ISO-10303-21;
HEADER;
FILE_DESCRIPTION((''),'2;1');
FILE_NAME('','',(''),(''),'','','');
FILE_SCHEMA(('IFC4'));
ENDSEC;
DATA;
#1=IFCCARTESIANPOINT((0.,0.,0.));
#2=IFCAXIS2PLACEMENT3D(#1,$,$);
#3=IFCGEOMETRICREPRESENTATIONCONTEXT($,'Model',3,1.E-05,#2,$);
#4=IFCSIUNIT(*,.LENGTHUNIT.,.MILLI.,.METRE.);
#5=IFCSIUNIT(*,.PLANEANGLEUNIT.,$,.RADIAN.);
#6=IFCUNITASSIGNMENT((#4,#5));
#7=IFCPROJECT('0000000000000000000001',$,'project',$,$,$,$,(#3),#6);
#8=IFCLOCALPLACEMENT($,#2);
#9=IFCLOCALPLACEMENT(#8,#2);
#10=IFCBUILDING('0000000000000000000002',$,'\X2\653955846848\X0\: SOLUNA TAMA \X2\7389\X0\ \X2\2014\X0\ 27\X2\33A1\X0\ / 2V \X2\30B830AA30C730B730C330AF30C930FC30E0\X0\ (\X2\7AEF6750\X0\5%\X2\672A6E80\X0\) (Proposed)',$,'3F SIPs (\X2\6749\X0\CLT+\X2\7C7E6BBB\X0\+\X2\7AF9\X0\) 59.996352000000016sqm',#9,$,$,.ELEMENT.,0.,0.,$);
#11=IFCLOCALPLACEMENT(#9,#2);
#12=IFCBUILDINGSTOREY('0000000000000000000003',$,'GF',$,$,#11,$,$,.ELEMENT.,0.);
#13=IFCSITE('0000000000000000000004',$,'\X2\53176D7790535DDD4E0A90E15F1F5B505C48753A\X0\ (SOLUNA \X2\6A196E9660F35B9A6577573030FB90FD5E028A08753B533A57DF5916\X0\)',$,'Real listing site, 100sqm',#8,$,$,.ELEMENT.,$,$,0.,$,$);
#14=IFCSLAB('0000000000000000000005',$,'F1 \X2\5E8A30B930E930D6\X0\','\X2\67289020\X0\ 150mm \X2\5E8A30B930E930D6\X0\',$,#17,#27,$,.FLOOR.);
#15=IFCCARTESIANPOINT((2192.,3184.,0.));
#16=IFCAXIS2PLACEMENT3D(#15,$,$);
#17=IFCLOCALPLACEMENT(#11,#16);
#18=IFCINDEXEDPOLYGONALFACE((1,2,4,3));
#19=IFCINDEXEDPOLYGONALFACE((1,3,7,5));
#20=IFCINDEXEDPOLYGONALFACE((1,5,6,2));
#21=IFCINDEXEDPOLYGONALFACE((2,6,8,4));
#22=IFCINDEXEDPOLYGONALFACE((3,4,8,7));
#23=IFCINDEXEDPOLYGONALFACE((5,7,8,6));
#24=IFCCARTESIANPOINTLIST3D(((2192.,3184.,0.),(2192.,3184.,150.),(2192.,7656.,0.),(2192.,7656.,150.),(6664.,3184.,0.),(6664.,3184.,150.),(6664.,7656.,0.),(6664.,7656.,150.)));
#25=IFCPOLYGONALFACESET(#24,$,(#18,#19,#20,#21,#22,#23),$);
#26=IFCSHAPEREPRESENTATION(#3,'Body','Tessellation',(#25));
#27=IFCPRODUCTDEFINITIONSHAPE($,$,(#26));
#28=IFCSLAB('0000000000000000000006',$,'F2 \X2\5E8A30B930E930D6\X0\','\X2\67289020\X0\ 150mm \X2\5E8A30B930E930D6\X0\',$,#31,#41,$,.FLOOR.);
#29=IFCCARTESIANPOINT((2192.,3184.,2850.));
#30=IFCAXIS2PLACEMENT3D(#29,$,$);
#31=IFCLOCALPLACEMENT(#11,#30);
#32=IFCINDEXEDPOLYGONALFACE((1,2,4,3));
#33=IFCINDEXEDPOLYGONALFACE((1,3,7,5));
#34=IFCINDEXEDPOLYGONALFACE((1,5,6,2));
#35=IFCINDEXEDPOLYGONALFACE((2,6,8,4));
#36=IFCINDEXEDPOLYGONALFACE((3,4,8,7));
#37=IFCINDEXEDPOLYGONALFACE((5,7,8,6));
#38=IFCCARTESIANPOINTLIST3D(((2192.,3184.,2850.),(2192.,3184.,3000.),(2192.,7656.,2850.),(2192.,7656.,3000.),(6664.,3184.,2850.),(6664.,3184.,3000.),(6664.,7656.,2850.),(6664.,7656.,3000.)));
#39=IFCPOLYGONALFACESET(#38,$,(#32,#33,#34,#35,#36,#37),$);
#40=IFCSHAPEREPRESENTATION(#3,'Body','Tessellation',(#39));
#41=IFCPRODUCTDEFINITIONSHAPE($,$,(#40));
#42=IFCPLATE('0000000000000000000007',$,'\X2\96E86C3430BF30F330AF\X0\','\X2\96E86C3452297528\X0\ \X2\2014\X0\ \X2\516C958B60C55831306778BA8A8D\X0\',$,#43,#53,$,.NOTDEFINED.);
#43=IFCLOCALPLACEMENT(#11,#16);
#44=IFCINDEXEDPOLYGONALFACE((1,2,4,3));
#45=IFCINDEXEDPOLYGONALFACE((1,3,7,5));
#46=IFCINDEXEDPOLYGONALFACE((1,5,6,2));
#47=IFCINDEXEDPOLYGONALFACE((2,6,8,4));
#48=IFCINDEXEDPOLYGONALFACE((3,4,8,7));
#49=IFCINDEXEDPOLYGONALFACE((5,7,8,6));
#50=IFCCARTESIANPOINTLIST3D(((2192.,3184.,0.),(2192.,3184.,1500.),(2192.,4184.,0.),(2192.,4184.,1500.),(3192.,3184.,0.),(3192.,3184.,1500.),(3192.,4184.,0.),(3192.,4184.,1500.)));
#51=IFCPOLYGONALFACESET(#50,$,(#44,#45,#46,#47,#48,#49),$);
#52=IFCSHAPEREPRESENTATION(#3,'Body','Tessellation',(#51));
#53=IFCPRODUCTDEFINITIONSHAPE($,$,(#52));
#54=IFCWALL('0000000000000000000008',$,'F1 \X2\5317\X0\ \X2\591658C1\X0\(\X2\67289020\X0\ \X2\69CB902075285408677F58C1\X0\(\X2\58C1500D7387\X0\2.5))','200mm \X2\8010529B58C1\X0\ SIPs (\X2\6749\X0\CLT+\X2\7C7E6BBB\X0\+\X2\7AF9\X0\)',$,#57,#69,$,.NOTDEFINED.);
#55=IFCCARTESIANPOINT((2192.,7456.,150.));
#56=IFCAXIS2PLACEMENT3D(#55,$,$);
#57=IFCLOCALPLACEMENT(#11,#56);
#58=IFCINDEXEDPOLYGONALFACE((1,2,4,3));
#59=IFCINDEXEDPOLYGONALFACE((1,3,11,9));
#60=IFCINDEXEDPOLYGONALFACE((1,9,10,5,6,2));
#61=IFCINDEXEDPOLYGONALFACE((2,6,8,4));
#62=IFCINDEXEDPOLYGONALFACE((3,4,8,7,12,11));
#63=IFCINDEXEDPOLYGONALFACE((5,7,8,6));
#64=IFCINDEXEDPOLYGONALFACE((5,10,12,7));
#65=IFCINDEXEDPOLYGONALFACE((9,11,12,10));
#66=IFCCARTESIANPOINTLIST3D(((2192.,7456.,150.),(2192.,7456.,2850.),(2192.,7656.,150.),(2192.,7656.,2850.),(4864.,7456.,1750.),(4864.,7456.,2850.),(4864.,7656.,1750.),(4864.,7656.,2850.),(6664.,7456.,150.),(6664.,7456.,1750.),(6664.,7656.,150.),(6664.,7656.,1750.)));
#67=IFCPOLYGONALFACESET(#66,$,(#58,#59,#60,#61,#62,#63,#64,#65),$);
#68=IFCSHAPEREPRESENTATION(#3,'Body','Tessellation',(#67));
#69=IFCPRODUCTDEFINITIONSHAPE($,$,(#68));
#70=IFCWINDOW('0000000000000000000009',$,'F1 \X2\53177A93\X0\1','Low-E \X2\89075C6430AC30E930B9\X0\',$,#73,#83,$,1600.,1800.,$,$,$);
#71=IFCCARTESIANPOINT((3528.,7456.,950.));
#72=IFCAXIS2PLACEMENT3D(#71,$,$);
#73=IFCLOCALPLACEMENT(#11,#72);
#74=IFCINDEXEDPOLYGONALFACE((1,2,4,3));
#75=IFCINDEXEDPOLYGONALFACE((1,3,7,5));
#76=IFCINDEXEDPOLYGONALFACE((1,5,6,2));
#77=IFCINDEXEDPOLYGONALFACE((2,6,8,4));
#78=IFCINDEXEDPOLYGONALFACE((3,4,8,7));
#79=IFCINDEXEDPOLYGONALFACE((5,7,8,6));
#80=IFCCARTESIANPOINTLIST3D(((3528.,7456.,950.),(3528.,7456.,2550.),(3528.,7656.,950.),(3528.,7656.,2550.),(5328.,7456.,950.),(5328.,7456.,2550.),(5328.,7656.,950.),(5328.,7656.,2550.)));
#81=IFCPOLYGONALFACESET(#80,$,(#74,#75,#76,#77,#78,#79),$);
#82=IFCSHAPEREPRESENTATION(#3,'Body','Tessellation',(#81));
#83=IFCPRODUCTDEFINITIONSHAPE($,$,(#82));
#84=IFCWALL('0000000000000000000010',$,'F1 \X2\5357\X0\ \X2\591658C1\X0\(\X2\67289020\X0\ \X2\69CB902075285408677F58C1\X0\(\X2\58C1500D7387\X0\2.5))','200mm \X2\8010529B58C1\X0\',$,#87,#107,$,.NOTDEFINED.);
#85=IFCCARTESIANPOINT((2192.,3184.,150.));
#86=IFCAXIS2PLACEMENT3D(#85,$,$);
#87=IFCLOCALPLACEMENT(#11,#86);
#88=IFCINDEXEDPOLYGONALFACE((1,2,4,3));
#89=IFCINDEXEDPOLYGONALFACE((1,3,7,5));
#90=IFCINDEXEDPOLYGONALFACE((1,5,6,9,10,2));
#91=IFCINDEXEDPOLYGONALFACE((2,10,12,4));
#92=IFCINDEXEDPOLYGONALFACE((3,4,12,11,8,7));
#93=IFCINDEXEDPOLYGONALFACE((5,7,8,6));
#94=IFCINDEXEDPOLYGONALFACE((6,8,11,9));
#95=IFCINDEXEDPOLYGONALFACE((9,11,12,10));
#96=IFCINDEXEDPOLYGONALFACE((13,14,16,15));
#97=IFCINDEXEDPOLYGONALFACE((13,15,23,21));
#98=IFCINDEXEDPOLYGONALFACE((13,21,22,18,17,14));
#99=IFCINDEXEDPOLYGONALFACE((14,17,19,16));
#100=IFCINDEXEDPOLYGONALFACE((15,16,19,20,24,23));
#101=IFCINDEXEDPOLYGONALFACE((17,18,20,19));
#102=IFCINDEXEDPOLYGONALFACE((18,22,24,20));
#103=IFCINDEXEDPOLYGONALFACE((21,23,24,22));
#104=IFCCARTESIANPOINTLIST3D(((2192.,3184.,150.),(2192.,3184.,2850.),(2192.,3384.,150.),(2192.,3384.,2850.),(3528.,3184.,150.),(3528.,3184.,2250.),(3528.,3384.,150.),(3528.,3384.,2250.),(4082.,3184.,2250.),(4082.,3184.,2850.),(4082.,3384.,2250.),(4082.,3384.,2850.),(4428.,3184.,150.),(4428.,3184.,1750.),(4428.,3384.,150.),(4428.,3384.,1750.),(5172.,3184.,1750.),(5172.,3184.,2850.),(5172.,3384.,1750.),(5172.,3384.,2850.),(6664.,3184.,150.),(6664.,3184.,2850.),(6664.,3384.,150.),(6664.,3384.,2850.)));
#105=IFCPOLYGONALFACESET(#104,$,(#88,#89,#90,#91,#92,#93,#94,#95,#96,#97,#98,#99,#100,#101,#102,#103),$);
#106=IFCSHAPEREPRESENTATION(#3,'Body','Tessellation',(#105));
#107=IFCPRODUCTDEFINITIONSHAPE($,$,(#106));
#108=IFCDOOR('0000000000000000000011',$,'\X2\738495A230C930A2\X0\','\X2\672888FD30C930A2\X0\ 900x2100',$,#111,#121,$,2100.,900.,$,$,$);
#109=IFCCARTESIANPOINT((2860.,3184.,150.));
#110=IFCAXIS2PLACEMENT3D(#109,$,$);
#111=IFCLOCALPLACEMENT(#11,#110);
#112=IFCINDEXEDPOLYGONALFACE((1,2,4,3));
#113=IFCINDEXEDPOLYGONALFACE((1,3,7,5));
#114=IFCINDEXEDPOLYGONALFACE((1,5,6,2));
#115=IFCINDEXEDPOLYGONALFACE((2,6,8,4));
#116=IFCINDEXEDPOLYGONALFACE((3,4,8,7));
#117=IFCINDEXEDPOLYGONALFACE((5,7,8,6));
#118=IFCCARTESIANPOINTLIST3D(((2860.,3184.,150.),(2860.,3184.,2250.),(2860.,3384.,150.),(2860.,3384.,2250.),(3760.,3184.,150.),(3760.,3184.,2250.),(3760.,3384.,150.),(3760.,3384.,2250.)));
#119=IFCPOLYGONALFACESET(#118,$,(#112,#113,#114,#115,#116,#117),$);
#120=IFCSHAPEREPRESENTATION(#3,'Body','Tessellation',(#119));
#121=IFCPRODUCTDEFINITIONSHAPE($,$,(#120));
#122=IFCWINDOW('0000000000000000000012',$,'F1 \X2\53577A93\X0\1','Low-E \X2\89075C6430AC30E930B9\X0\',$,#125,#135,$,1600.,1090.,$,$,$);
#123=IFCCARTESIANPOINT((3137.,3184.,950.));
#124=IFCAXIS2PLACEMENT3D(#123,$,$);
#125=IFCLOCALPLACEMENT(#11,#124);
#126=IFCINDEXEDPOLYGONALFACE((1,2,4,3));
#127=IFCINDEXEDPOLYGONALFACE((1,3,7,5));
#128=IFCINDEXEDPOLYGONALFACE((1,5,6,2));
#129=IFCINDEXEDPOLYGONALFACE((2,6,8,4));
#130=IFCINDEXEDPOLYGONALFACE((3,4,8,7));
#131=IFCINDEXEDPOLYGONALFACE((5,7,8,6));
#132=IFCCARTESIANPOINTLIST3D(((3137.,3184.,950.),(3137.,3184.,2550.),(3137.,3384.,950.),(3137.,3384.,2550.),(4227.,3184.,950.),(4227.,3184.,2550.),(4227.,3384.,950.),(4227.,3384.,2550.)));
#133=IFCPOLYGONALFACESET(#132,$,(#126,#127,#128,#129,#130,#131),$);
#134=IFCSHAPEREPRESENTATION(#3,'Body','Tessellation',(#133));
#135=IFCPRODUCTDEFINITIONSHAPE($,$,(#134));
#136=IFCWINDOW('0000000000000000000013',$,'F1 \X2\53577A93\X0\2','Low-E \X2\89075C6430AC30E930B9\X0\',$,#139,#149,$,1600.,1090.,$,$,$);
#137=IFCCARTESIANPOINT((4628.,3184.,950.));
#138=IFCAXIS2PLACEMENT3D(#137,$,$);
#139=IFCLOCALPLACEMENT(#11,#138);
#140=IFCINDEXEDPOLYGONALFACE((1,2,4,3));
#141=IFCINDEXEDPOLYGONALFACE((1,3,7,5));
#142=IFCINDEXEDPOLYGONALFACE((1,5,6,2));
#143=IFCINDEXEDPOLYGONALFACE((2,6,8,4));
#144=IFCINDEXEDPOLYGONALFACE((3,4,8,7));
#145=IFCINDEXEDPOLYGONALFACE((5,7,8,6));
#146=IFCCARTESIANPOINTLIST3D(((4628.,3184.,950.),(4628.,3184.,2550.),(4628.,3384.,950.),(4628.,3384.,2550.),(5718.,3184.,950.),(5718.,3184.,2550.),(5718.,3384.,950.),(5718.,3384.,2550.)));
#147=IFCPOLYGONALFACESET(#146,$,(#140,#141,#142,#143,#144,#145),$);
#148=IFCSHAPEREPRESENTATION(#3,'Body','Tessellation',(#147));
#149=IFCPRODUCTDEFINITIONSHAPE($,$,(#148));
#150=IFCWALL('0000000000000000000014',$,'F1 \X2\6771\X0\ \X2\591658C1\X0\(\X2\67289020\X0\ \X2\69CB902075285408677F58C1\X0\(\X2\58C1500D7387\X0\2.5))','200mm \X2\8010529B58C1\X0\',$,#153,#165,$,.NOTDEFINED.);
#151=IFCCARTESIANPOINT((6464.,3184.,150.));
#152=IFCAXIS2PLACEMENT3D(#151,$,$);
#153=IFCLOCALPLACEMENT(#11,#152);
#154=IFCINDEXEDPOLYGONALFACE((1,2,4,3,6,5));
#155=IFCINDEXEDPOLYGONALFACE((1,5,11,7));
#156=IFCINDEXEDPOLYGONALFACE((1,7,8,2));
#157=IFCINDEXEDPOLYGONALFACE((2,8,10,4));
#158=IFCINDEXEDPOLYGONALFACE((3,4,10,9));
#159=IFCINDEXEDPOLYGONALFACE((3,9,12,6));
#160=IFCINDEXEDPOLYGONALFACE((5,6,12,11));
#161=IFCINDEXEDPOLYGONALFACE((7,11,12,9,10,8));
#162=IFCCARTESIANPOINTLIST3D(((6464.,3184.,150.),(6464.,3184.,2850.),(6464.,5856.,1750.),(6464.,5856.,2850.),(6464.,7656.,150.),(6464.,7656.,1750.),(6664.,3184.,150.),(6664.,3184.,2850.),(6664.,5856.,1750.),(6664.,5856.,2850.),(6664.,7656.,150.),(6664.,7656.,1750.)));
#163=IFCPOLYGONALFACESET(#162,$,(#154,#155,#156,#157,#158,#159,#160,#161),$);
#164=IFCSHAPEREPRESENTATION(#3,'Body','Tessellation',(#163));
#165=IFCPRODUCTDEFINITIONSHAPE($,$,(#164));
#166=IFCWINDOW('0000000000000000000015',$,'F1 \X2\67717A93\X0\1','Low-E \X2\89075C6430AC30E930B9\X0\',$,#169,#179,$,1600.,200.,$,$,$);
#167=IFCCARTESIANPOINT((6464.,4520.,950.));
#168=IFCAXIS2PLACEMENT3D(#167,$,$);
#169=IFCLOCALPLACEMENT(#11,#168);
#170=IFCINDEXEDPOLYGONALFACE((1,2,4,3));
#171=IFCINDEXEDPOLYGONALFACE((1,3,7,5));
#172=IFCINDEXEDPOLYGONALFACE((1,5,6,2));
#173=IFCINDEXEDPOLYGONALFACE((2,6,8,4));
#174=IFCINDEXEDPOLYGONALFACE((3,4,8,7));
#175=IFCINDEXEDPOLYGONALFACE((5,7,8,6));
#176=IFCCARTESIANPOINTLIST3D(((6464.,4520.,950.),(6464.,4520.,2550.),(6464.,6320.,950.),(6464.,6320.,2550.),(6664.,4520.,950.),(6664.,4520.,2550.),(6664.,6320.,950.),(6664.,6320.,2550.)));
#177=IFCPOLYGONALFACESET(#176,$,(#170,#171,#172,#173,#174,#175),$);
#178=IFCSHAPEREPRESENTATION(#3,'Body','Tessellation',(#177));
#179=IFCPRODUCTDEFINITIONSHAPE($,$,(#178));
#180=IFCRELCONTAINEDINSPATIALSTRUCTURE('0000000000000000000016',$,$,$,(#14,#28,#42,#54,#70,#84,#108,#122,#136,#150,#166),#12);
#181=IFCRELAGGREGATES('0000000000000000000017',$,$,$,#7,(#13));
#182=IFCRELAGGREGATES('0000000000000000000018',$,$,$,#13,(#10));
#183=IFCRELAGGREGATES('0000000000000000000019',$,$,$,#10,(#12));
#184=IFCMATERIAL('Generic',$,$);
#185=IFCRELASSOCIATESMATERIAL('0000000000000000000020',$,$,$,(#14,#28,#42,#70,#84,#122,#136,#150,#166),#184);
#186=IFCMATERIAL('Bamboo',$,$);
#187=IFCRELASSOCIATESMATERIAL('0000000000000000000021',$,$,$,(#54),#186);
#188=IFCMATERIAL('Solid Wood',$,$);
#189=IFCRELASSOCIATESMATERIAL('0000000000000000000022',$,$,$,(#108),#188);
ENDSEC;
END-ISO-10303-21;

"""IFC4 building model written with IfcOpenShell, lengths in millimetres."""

from ifc_helpers import new_model, si_unit, frame, frame_2d, origin, place, context, project, spatial, rectangle, extrude, material, element, fill, save


model = new_model("IFC4")

# Units and contexts
model_context = context("Model", 3, precision=1e-05, world=origin())
ifc_project = project(units=[si_unit("LENGTHUNIT", "METRE", prefix="MILLI"), si_unit("PLANEANGLEUNIT", "RADIAN")], contexts=[model_context])

# Site, building, storey
site_placement = place(None, origin())
site = spatial("IfcSite", under=ifc_project, at=site_placement, Name="北海道川上郡弟子屈町 (SOLUNA 標準想定敷地・都市計画区域外)", ObjectType="Real listing site, 100sqm", CompositionType="ELEMENT", RefElevation=0.0)
building_placement = place(site_placement, origin())
building = spatial("IfcBuilding", under=site, at=building_placement, Name="改善案: SOLUNA TAMA 玉 — 27㎡ / 2V ジオデシックドーム (端材5%未満) (Proposed)", ObjectType="3F SIPs (杉CLT+籾殻+竹) 59.996352000000016sqm", CompositionType="ELEMENT", ElevationOfRefHeight=0.0, ElevationOfTerrain=0.0)
storey_placement = place(building_placement, origin())
storey = spatial("IfcBuildingStorey", under=building, at=storey_placement, Name="GF", CompositionType="ELEMENT", Elevation=0.0)

# Slabs
ifc_material_1 = material(Name="Generic")
slab_1_placement = place(storey_placement, frame((2192.0, 3184.0, 0.0)))
element("IfcSlab", 1, at=slab_1_placement, inside=storey, material=ifc_material_1, Name="F1 床スラブ", Description="木造 150mm 床スラブ", PredefinedType="FLOOR", context=model_context, shape_type="SweptSolid", body=[
    extrude(rectangle(XDim=4472.0, YDim=4472.0, at=frame_2d((2236.0, 2236.0))), frame((2192.0, 3184.0, 0.0)), (0.0, 0.0, 1.0), 150.0),
])
slab_2_placement = place(storey_placement, frame((2192.0, 3184.0, 2850.0)))
element("IfcSlab", 2, at=slab_2_placement, inside=storey, material=ifc_material_1, Name="F2 床スラブ", Description="木造 150mm 床スラブ", PredefinedType="FLOOR", context=model_context, shape_type="SweptSolid", body=[
    extrude(rectangle(XDim=4472.0, YDim=4472.0, at=frame_2d((2236.0, 2236.0))), frame((2192.0, 3184.0, 2850.0)), (0.0, 0.0, 1.0), 150.0),
])

# Plate
plate_placement = place(storey_placement, frame((2192.0, 3184.0, 0.0)))
element("IfcPlate", 3, at=plate_placement, inside=storey, material=ifc_material_1, Name="雨水タンク", Description="雨水利用 — 公開情報で確認", PredefinedType="NOTDEFINED", context=model_context, shape_type="SweptSolid", body=[
    extrude(rectangle(XDim=1000.0, YDim=1000.0, at=frame_2d((500.0, 500.0))), frame((2192.0, 3184.0, 0.0)), (0.0, 0.0, 1.0), 1500.0),
])

# Wall, opening, window
ifc_material_2 = material(Name="Bamboo")
wall_1_placement = place(storey_placement, frame((2192.0, 7456.0, 150.0)))
wall_1 = element("IfcWall", 4, at=wall_1_placement, inside=storey, material=ifc_material_2, Name="F1 北 外壁(木造 構造用合板壁(壁倍率2.5))", Description="200mm 耐力壁 SIPs (杉CLT+籾殻+竹)", PredefinedType="NOTDEFINED", context=model_context, shape_type="SweptSolid", body=[
    extrude(rectangle(XDim=4472.0, YDim=200.0, at=frame_2d((2236.0, 100.0))), frame((2192.0, 7456.0, 150.0)), (0.0, 0.0, 1.0), 2700.0),
])
opening_1_placement = place(storey_placement, frame((3528.0, 7456.0, 950.0)))
opening_1 = element("IfcOpeningElement", 5, at=opening_1_placement, cuts=wall_1, PredefinedType="NOTDEFINED", context=model_context, shape_type="SweptSolid", body=[
    extrude(rectangle(XDim=1800.0, YDim=200.0, at=frame_2d((900.0, 100.0))), frame((3528.0, 7456.0, 950.0)), (0.0, 0.0, 1.0), 1600.0),
])
window_1_placement = place(storey_placement, frame((3528.0, 7456.0, 950.0)))
window_1 = element("IfcWindow", 6, at=window_1_placement, inside=storey, material=ifc_material_1, Name="F1 北窓1", Description="Low-E 複層ガラス", OverallHeight=1600.0, OverallWidth=1800.0, context=model_context, shape_type="SweptSolid", body=[
    extrude(rectangle(XDim=1800.0, YDim=200.0, at=frame_2d((900.0, 100.0))), frame((3528.0, 7456.0, 950.0)), (0.0, 0.0, 1.0), 1600.0),
])
fill(opening_1, window_1)

# Wall, openings, door, windows
wall_2_placement = place(storey_placement, frame((2192.0, 3184.0, 150.0)))
wall_2 = element("IfcWall", 7, at=wall_2_placement, inside=storey, material=ifc_material_1, Name="F1 南 外壁(木造 構造用合板壁(壁倍率2.5))", Description="200mm 耐力壁", PredefinedType="NOTDEFINED", context=model_context, shape_type="SweptSolid", body=[
    extrude(rectangle(XDim=4472.0, YDim=200.0, at=frame_2d((2236.0, 100.0))), frame((2192.0, 3184.0, 150.0)), (0.0, 0.0, 1.0), 2700.0),
])
opening_2_placement = place(storey_placement, frame((2860.0, 3184.0, 150.0)))
opening_2 = element("IfcOpeningElement", 8, at=opening_2_placement, cuts=wall_2, PredefinedType="NOTDEFINED", context=model_context, shape_type="SweptSolid", body=[
    extrude(rectangle(XDim=900.0, YDim=200.0, at=frame_2d((450.0, 100.0))), frame((2860.0, 3184.0, 150.0)), (0.0, 0.0, 1.0), 2100.0),
])
opening_3_placement = place(storey_placement, frame((3137.0, 3184.0, 950.0)))
opening_3 = element("IfcOpeningElement", 9, at=opening_3_placement, cuts=wall_2, PredefinedType="NOTDEFINED", context=model_context, shape_type="SweptSolid", body=[
    extrude(rectangle(XDim=1090.0, YDim=200.0, at=frame_2d((545.0, 100.0))), frame((3137.0, 3184.0, 950.0)), (0.0, 0.0, 1.0), 1600.0),
])
opening_4_placement = place(storey_placement, frame((4628.0, 3184.0, 950.0)))
opening_4 = element("IfcOpeningElement", 10, at=opening_4_placement, cuts=wall_2, PredefinedType="NOTDEFINED", context=model_context, shape_type="SweptSolid", body=[
    extrude(rectangle(XDim=1090.0, YDim=200.0, at=frame_2d((545.0, 100.0))), frame((4628.0, 3184.0, 950.0)), (0.0, 0.0, 1.0), 1600.0),
])
ifc_material_3 = material(Name="Solid Wood")
door_placement = place(storey_placement, frame((2860.0, 3184.0, 150.0)))
door = element("IfcDoor", 11, at=door_placement, inside=storey, material=ifc_material_3, Name="玄関ドア", Description="木製ドア 900x2100", OverallHeight=2100.0, OverallWidth=900.0, context=model_context, shape_type="SweptSolid", body=[
    extrude(rectangle(XDim=900.0, YDim=200.0, at=frame_2d((450.0, 100.0))), frame((2860.0, 3184.0, 150.0)), (0.0, 0.0, 1.0), 2100.0),
])
fill(opening_2, door)
window_2_placement = place(storey_placement, frame((3137.0, 3184.0, 950.0)))
window_2 = element("IfcWindow", 12, at=window_2_placement, inside=storey, material=ifc_material_1, Name="F1 南窓1", Description="Low-E 複層ガラス", OverallHeight=1600.0, OverallWidth=1090.0, context=model_context, shape_type="SweptSolid", body=[
    extrude(rectangle(XDim=1090.0, YDim=200.0, at=frame_2d((545.0, 100.0))), frame((3137.0, 3184.0, 950.0)), (0.0, 0.0, 1.0), 1600.0),
])
fill(opening_3, window_2)
window_3_placement = place(storey_placement, frame((4628.0, 3184.0, 950.0)))
window_3 = element("IfcWindow", 13, at=window_3_placement, inside=storey, material=ifc_material_1, Name="F1 南窓2", Description="Low-E 複層ガラス", OverallHeight=1600.0, OverallWidth=1090.0, context=model_context, shape_type="SweptSolid", body=[
    extrude(rectangle(XDim=1090.0, YDim=200.0, at=frame_2d((545.0, 100.0))), frame((4628.0, 3184.0, 950.0)), (0.0, 0.0, 1.0), 1600.0),
])
fill(opening_4, window_3)

# Wall, opening, window
wall_3_placement = place(storey_placement, frame((6464.0, 3184.0, 150.0)))
wall_3 = element("IfcWall", 14, at=wall_3_placement, inside=storey, material=ifc_material_1, Name="F1 東 外壁(木造 構造用合板壁(壁倍率2.5))", Description="200mm 耐力壁", PredefinedType="NOTDEFINED", context=model_context, shape_type="SweptSolid", body=[
    extrude(rectangle(XDim=200.0, YDim=4472.0, at=frame_2d((100.0, 2236.0))), frame((6464.0, 3184.0, 150.0)), (0.0, 0.0, 1.0), 2700.0),
])
opening_5_placement = place(storey_placement, frame((6464.0, 4520.0, 950.0)))
opening_5 = element("IfcOpeningElement", 15, at=opening_5_placement, cuts=wall_3, PredefinedType="NOTDEFINED", context=model_context, shape_type="SweptSolid", body=[
    extrude(rectangle(XDim=200.0, YDim=1800.0, at=frame_2d((100.0, 900.0))), frame((6464.0, 4520.0, 950.0)), (0.0, 0.0, 1.0), 1600.0),
])
window_4_placement = place(storey_placement, frame((6464.0, 4520.0, 950.0)))
window_4 = element("IfcWindow", 16, at=window_4_placement, inside=storey, material=ifc_material_1, Name="F1 東窓1", Description="Low-E 複層ガラス", OverallHeight=1600.0, OverallWidth=200.0, context=model_context, shape_type="SweptSolid", body=[
    extrude(rectangle(XDim=200.0, YDim=1800.0, at=frame_2d((100.0, 900.0))), frame((6464.0, 4520.0, 950.0)), (0.0, 0.0, 1.0), 1600.0),
])
fill(opening_5, window_4)

save(model, "model.ifc")
